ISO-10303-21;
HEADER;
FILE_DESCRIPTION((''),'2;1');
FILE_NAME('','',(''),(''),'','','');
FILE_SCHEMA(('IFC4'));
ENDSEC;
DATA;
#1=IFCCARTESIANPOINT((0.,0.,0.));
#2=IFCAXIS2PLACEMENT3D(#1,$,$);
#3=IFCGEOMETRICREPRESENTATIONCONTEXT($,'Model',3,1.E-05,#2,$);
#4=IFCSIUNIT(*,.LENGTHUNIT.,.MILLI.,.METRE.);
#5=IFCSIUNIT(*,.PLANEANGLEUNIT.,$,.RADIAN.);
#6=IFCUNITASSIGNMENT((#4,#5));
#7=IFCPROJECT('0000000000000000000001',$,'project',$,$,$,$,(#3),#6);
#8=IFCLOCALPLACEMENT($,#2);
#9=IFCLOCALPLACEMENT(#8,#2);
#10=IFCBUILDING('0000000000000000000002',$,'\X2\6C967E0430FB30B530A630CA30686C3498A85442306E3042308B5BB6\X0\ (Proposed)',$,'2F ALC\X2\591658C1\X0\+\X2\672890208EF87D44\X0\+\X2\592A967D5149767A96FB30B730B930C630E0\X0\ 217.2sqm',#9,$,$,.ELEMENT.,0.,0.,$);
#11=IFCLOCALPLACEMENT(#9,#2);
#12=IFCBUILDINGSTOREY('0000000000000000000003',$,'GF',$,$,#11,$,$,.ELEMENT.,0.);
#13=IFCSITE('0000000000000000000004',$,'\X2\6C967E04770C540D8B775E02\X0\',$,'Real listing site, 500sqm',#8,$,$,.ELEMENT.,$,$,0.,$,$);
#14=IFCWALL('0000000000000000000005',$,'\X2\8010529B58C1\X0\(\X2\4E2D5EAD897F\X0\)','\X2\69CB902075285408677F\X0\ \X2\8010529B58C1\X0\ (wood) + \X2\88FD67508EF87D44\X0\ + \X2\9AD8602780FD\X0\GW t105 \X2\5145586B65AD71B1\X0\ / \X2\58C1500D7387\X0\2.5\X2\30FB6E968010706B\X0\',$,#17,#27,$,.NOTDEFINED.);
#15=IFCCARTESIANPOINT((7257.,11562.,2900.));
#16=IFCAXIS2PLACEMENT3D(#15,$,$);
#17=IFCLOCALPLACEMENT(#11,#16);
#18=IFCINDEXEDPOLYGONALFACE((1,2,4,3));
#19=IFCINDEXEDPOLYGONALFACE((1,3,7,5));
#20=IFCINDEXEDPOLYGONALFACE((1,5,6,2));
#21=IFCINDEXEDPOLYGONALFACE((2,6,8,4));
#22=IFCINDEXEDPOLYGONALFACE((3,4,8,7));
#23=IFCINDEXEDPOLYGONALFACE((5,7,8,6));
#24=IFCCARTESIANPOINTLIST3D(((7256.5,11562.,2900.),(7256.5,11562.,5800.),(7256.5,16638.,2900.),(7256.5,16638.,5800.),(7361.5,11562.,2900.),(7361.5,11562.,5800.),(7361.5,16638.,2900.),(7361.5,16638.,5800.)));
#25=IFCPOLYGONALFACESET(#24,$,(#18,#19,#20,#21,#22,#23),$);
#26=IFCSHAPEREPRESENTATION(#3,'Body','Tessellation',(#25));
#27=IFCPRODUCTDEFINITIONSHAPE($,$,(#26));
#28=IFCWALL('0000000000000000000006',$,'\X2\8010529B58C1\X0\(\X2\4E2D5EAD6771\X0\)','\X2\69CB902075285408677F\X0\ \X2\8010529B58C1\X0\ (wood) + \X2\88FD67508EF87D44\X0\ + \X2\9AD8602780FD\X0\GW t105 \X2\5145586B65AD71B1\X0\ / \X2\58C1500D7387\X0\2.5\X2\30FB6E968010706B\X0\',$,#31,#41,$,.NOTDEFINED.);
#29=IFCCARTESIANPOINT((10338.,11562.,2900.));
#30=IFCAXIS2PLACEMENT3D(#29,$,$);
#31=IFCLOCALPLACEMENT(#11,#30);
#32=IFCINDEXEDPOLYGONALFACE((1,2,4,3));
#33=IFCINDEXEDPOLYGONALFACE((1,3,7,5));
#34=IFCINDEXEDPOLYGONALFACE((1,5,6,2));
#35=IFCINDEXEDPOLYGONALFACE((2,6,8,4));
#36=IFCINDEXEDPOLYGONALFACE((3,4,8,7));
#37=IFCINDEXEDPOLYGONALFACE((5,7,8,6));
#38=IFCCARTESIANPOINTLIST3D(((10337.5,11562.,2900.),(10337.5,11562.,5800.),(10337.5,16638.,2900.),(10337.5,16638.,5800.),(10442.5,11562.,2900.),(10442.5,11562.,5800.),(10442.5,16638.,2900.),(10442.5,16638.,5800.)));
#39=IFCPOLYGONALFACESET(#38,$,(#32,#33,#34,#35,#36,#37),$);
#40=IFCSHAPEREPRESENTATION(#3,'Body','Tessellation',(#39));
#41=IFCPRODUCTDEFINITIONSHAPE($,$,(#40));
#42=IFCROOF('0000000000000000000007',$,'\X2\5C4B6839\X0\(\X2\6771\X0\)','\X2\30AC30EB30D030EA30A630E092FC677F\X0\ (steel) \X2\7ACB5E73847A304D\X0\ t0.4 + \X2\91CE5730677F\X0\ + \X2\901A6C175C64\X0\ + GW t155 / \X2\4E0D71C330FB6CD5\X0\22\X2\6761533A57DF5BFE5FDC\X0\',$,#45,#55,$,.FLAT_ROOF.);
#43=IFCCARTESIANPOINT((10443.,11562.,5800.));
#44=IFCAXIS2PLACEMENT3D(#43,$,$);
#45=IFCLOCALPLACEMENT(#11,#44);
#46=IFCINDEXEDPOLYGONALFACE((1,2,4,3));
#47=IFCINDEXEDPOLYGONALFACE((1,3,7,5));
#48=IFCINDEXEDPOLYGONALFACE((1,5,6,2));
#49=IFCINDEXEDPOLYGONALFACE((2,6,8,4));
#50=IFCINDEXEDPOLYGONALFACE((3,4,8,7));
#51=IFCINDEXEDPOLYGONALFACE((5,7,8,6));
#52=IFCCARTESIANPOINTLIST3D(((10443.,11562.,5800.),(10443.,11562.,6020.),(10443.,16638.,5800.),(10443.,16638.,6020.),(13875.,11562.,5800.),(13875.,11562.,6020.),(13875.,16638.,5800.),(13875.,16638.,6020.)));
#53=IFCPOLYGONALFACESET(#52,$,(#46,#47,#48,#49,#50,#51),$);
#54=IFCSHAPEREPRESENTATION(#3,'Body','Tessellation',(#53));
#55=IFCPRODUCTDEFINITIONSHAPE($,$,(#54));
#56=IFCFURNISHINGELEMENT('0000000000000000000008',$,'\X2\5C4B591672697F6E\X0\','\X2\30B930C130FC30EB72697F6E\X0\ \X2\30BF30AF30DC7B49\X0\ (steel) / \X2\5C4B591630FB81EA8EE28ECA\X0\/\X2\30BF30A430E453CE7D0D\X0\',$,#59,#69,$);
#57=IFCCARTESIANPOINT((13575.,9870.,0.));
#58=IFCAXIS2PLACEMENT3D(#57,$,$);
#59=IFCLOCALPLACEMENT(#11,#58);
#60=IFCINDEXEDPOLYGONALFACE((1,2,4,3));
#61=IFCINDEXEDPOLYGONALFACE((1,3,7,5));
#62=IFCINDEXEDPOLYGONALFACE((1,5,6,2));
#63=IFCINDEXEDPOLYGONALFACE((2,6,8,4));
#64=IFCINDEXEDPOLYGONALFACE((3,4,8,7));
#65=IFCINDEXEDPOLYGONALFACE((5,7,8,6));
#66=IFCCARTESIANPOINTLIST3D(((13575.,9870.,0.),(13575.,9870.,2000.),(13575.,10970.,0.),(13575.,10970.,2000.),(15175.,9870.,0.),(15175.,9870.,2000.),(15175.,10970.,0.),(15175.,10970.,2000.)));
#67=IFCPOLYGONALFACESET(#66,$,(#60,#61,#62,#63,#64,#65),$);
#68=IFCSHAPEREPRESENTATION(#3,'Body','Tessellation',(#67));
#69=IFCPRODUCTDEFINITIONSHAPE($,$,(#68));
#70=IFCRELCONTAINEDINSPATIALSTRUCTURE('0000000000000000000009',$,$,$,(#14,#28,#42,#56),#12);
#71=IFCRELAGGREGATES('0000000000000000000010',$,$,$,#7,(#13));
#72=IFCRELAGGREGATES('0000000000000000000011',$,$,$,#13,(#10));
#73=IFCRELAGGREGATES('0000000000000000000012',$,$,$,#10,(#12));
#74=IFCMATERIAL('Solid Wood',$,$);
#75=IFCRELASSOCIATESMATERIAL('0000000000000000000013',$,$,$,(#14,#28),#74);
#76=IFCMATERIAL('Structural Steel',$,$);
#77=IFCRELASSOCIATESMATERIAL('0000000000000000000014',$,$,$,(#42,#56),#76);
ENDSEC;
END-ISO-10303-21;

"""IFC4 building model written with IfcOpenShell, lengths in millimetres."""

from ifc_helpers import new_model, si_unit, frame, frame_2d, origin, place, context, project, spatial, rectangle, extrude, material, element, save


model = new_model("IFC4")

# Units and contexts
model_context = context("Model", 3, precision=1e-05, world=origin())
ifc_project = project(units=[si_unit("LENGTHUNIT", "METRE", prefix="MILLI"), si_unit("PLANEANGLEUNIT", "RADIAN")], contexts=[model_context])

# Site, building, storey
site_placement = place(None, origin())
site = spatial("IfcSite", under=ifc_project, at=site_placement, Name="沖縄県名護市", ObjectType="Real listing site, 500sqm", CompositionType="ELEMENT", RefElevation=0.0)
building_placement = place(site_placement, origin())
building = spatial("IfcBuilding", under=site, at=building_placement, Name="沖縄・サウナと水風呂のある家 (Proposed)", ObjectType="2F ALC外壁+木造軸組+太陽光発電システム 217.2sqm", CompositionType="ELEMENT", ElevationOfRefHeight=0.0, ElevationOfTerrain=0.0)
storey_placement = place(building_placement, origin())
storey = spatial("IfcBuildingStorey", under=building, at=storey_placement, Name="GF", CompositionType="ELEMENT", Elevation=0.0)

# Shared definitions
ifc_material_1 = material(Name="Solid Wood")

# Walls
wall_1_placement = place(storey_placement, frame((7257.0, 11562.0, 2900.0)))
element("IfcWall", 1, at=wall_1_placement, inside=storey, material=ifc_material_1, Name="耐力壁(中庭西)", Description="構造用合板 耐力壁 (wood) + 製材軸組 + 高性能GW t105 充填断熱 / 壁倍率2.5・準耐火", PredefinedType="NOTDEFINED", context=model_context, shape_type="SweptSolid", body=[
    extrude(rectangle(XDim=105.0, YDim=5076.0, at=frame_2d((52.0, 2538.0))), frame((7257.0, 11562.0, 2900.0)), (0.0, 0.0, 1.0), 2900.0),
])
wall_2_placement = place(storey_placement, frame((10338.0, 11562.0, 2900.0)))
element("IfcWall", 2, at=wall_2_placement, inside=storey, material=ifc_material_1, Name="耐力壁(中庭東)", Description="構造用合板 耐力壁 (wood) + 製材軸組 + 高性能GW t105 充填断熱 / 壁倍率2.5・準耐火", PredefinedType="NOTDEFINED", context=model_context, shape_type="SweptSolid", body=[
    extrude(rectangle(XDim=105.0, YDim=5076.0, at=frame_2d((52.0, 2538.0))), frame((10338.0, 11562.0, 2900.0)), (0.0, 0.0, 1.0), 2900.0),
])

# Roof
ifc_material_2 = material(Name="Structural Steel")
for number, where, name in (
    (3, (10443.0, 11562.0, 5800.0), "屋根(東)"),
):
    element("IfcRoof", number, at=place(storey_placement, frame(where)), inside=storey, material=ifc_material_2, Name=name, Description="ガルバリウム鋼板 (steel) 立平葺き t0.4 + 野地板 + 通気層 + GW t155 / 不燃・法22条区域対応", PredefinedType="FLAT_ROOF", context=model_context, shape_type="SweptSolid", body=[
        extrude(rectangle(XDim=3432.0, YDim=5076.0, at=frame_2d((1716.0, 2538.0))), frame((10443.0, 11562.0, 5800.0)), (0.0, 0.0, 1.0), 220.0),
    ])

# Furnishing element
furnishing_placement = place(storey_placement, frame((13575.0, 9870.0, 0.0)))
element("IfcFurnishingElement", 4, at=furnishing_placement, inside=storey, material=ifc_material_2, Name="屋外物置", Description="スチール物置 タクボ等 (steel) / 屋外・自転車/タイヤ収納", context=model_context, shape_type="SweptSolid", body=[
    extrude(rectangle(XDim=1600.0, YDim=1100.0, at=frame_2d((800.0, 550.0))), frame((13575.0, 9870.0, 0.0)), (0.0, 0.0, 1.0), 2000.0),
])

save(model, "model.ifc")
